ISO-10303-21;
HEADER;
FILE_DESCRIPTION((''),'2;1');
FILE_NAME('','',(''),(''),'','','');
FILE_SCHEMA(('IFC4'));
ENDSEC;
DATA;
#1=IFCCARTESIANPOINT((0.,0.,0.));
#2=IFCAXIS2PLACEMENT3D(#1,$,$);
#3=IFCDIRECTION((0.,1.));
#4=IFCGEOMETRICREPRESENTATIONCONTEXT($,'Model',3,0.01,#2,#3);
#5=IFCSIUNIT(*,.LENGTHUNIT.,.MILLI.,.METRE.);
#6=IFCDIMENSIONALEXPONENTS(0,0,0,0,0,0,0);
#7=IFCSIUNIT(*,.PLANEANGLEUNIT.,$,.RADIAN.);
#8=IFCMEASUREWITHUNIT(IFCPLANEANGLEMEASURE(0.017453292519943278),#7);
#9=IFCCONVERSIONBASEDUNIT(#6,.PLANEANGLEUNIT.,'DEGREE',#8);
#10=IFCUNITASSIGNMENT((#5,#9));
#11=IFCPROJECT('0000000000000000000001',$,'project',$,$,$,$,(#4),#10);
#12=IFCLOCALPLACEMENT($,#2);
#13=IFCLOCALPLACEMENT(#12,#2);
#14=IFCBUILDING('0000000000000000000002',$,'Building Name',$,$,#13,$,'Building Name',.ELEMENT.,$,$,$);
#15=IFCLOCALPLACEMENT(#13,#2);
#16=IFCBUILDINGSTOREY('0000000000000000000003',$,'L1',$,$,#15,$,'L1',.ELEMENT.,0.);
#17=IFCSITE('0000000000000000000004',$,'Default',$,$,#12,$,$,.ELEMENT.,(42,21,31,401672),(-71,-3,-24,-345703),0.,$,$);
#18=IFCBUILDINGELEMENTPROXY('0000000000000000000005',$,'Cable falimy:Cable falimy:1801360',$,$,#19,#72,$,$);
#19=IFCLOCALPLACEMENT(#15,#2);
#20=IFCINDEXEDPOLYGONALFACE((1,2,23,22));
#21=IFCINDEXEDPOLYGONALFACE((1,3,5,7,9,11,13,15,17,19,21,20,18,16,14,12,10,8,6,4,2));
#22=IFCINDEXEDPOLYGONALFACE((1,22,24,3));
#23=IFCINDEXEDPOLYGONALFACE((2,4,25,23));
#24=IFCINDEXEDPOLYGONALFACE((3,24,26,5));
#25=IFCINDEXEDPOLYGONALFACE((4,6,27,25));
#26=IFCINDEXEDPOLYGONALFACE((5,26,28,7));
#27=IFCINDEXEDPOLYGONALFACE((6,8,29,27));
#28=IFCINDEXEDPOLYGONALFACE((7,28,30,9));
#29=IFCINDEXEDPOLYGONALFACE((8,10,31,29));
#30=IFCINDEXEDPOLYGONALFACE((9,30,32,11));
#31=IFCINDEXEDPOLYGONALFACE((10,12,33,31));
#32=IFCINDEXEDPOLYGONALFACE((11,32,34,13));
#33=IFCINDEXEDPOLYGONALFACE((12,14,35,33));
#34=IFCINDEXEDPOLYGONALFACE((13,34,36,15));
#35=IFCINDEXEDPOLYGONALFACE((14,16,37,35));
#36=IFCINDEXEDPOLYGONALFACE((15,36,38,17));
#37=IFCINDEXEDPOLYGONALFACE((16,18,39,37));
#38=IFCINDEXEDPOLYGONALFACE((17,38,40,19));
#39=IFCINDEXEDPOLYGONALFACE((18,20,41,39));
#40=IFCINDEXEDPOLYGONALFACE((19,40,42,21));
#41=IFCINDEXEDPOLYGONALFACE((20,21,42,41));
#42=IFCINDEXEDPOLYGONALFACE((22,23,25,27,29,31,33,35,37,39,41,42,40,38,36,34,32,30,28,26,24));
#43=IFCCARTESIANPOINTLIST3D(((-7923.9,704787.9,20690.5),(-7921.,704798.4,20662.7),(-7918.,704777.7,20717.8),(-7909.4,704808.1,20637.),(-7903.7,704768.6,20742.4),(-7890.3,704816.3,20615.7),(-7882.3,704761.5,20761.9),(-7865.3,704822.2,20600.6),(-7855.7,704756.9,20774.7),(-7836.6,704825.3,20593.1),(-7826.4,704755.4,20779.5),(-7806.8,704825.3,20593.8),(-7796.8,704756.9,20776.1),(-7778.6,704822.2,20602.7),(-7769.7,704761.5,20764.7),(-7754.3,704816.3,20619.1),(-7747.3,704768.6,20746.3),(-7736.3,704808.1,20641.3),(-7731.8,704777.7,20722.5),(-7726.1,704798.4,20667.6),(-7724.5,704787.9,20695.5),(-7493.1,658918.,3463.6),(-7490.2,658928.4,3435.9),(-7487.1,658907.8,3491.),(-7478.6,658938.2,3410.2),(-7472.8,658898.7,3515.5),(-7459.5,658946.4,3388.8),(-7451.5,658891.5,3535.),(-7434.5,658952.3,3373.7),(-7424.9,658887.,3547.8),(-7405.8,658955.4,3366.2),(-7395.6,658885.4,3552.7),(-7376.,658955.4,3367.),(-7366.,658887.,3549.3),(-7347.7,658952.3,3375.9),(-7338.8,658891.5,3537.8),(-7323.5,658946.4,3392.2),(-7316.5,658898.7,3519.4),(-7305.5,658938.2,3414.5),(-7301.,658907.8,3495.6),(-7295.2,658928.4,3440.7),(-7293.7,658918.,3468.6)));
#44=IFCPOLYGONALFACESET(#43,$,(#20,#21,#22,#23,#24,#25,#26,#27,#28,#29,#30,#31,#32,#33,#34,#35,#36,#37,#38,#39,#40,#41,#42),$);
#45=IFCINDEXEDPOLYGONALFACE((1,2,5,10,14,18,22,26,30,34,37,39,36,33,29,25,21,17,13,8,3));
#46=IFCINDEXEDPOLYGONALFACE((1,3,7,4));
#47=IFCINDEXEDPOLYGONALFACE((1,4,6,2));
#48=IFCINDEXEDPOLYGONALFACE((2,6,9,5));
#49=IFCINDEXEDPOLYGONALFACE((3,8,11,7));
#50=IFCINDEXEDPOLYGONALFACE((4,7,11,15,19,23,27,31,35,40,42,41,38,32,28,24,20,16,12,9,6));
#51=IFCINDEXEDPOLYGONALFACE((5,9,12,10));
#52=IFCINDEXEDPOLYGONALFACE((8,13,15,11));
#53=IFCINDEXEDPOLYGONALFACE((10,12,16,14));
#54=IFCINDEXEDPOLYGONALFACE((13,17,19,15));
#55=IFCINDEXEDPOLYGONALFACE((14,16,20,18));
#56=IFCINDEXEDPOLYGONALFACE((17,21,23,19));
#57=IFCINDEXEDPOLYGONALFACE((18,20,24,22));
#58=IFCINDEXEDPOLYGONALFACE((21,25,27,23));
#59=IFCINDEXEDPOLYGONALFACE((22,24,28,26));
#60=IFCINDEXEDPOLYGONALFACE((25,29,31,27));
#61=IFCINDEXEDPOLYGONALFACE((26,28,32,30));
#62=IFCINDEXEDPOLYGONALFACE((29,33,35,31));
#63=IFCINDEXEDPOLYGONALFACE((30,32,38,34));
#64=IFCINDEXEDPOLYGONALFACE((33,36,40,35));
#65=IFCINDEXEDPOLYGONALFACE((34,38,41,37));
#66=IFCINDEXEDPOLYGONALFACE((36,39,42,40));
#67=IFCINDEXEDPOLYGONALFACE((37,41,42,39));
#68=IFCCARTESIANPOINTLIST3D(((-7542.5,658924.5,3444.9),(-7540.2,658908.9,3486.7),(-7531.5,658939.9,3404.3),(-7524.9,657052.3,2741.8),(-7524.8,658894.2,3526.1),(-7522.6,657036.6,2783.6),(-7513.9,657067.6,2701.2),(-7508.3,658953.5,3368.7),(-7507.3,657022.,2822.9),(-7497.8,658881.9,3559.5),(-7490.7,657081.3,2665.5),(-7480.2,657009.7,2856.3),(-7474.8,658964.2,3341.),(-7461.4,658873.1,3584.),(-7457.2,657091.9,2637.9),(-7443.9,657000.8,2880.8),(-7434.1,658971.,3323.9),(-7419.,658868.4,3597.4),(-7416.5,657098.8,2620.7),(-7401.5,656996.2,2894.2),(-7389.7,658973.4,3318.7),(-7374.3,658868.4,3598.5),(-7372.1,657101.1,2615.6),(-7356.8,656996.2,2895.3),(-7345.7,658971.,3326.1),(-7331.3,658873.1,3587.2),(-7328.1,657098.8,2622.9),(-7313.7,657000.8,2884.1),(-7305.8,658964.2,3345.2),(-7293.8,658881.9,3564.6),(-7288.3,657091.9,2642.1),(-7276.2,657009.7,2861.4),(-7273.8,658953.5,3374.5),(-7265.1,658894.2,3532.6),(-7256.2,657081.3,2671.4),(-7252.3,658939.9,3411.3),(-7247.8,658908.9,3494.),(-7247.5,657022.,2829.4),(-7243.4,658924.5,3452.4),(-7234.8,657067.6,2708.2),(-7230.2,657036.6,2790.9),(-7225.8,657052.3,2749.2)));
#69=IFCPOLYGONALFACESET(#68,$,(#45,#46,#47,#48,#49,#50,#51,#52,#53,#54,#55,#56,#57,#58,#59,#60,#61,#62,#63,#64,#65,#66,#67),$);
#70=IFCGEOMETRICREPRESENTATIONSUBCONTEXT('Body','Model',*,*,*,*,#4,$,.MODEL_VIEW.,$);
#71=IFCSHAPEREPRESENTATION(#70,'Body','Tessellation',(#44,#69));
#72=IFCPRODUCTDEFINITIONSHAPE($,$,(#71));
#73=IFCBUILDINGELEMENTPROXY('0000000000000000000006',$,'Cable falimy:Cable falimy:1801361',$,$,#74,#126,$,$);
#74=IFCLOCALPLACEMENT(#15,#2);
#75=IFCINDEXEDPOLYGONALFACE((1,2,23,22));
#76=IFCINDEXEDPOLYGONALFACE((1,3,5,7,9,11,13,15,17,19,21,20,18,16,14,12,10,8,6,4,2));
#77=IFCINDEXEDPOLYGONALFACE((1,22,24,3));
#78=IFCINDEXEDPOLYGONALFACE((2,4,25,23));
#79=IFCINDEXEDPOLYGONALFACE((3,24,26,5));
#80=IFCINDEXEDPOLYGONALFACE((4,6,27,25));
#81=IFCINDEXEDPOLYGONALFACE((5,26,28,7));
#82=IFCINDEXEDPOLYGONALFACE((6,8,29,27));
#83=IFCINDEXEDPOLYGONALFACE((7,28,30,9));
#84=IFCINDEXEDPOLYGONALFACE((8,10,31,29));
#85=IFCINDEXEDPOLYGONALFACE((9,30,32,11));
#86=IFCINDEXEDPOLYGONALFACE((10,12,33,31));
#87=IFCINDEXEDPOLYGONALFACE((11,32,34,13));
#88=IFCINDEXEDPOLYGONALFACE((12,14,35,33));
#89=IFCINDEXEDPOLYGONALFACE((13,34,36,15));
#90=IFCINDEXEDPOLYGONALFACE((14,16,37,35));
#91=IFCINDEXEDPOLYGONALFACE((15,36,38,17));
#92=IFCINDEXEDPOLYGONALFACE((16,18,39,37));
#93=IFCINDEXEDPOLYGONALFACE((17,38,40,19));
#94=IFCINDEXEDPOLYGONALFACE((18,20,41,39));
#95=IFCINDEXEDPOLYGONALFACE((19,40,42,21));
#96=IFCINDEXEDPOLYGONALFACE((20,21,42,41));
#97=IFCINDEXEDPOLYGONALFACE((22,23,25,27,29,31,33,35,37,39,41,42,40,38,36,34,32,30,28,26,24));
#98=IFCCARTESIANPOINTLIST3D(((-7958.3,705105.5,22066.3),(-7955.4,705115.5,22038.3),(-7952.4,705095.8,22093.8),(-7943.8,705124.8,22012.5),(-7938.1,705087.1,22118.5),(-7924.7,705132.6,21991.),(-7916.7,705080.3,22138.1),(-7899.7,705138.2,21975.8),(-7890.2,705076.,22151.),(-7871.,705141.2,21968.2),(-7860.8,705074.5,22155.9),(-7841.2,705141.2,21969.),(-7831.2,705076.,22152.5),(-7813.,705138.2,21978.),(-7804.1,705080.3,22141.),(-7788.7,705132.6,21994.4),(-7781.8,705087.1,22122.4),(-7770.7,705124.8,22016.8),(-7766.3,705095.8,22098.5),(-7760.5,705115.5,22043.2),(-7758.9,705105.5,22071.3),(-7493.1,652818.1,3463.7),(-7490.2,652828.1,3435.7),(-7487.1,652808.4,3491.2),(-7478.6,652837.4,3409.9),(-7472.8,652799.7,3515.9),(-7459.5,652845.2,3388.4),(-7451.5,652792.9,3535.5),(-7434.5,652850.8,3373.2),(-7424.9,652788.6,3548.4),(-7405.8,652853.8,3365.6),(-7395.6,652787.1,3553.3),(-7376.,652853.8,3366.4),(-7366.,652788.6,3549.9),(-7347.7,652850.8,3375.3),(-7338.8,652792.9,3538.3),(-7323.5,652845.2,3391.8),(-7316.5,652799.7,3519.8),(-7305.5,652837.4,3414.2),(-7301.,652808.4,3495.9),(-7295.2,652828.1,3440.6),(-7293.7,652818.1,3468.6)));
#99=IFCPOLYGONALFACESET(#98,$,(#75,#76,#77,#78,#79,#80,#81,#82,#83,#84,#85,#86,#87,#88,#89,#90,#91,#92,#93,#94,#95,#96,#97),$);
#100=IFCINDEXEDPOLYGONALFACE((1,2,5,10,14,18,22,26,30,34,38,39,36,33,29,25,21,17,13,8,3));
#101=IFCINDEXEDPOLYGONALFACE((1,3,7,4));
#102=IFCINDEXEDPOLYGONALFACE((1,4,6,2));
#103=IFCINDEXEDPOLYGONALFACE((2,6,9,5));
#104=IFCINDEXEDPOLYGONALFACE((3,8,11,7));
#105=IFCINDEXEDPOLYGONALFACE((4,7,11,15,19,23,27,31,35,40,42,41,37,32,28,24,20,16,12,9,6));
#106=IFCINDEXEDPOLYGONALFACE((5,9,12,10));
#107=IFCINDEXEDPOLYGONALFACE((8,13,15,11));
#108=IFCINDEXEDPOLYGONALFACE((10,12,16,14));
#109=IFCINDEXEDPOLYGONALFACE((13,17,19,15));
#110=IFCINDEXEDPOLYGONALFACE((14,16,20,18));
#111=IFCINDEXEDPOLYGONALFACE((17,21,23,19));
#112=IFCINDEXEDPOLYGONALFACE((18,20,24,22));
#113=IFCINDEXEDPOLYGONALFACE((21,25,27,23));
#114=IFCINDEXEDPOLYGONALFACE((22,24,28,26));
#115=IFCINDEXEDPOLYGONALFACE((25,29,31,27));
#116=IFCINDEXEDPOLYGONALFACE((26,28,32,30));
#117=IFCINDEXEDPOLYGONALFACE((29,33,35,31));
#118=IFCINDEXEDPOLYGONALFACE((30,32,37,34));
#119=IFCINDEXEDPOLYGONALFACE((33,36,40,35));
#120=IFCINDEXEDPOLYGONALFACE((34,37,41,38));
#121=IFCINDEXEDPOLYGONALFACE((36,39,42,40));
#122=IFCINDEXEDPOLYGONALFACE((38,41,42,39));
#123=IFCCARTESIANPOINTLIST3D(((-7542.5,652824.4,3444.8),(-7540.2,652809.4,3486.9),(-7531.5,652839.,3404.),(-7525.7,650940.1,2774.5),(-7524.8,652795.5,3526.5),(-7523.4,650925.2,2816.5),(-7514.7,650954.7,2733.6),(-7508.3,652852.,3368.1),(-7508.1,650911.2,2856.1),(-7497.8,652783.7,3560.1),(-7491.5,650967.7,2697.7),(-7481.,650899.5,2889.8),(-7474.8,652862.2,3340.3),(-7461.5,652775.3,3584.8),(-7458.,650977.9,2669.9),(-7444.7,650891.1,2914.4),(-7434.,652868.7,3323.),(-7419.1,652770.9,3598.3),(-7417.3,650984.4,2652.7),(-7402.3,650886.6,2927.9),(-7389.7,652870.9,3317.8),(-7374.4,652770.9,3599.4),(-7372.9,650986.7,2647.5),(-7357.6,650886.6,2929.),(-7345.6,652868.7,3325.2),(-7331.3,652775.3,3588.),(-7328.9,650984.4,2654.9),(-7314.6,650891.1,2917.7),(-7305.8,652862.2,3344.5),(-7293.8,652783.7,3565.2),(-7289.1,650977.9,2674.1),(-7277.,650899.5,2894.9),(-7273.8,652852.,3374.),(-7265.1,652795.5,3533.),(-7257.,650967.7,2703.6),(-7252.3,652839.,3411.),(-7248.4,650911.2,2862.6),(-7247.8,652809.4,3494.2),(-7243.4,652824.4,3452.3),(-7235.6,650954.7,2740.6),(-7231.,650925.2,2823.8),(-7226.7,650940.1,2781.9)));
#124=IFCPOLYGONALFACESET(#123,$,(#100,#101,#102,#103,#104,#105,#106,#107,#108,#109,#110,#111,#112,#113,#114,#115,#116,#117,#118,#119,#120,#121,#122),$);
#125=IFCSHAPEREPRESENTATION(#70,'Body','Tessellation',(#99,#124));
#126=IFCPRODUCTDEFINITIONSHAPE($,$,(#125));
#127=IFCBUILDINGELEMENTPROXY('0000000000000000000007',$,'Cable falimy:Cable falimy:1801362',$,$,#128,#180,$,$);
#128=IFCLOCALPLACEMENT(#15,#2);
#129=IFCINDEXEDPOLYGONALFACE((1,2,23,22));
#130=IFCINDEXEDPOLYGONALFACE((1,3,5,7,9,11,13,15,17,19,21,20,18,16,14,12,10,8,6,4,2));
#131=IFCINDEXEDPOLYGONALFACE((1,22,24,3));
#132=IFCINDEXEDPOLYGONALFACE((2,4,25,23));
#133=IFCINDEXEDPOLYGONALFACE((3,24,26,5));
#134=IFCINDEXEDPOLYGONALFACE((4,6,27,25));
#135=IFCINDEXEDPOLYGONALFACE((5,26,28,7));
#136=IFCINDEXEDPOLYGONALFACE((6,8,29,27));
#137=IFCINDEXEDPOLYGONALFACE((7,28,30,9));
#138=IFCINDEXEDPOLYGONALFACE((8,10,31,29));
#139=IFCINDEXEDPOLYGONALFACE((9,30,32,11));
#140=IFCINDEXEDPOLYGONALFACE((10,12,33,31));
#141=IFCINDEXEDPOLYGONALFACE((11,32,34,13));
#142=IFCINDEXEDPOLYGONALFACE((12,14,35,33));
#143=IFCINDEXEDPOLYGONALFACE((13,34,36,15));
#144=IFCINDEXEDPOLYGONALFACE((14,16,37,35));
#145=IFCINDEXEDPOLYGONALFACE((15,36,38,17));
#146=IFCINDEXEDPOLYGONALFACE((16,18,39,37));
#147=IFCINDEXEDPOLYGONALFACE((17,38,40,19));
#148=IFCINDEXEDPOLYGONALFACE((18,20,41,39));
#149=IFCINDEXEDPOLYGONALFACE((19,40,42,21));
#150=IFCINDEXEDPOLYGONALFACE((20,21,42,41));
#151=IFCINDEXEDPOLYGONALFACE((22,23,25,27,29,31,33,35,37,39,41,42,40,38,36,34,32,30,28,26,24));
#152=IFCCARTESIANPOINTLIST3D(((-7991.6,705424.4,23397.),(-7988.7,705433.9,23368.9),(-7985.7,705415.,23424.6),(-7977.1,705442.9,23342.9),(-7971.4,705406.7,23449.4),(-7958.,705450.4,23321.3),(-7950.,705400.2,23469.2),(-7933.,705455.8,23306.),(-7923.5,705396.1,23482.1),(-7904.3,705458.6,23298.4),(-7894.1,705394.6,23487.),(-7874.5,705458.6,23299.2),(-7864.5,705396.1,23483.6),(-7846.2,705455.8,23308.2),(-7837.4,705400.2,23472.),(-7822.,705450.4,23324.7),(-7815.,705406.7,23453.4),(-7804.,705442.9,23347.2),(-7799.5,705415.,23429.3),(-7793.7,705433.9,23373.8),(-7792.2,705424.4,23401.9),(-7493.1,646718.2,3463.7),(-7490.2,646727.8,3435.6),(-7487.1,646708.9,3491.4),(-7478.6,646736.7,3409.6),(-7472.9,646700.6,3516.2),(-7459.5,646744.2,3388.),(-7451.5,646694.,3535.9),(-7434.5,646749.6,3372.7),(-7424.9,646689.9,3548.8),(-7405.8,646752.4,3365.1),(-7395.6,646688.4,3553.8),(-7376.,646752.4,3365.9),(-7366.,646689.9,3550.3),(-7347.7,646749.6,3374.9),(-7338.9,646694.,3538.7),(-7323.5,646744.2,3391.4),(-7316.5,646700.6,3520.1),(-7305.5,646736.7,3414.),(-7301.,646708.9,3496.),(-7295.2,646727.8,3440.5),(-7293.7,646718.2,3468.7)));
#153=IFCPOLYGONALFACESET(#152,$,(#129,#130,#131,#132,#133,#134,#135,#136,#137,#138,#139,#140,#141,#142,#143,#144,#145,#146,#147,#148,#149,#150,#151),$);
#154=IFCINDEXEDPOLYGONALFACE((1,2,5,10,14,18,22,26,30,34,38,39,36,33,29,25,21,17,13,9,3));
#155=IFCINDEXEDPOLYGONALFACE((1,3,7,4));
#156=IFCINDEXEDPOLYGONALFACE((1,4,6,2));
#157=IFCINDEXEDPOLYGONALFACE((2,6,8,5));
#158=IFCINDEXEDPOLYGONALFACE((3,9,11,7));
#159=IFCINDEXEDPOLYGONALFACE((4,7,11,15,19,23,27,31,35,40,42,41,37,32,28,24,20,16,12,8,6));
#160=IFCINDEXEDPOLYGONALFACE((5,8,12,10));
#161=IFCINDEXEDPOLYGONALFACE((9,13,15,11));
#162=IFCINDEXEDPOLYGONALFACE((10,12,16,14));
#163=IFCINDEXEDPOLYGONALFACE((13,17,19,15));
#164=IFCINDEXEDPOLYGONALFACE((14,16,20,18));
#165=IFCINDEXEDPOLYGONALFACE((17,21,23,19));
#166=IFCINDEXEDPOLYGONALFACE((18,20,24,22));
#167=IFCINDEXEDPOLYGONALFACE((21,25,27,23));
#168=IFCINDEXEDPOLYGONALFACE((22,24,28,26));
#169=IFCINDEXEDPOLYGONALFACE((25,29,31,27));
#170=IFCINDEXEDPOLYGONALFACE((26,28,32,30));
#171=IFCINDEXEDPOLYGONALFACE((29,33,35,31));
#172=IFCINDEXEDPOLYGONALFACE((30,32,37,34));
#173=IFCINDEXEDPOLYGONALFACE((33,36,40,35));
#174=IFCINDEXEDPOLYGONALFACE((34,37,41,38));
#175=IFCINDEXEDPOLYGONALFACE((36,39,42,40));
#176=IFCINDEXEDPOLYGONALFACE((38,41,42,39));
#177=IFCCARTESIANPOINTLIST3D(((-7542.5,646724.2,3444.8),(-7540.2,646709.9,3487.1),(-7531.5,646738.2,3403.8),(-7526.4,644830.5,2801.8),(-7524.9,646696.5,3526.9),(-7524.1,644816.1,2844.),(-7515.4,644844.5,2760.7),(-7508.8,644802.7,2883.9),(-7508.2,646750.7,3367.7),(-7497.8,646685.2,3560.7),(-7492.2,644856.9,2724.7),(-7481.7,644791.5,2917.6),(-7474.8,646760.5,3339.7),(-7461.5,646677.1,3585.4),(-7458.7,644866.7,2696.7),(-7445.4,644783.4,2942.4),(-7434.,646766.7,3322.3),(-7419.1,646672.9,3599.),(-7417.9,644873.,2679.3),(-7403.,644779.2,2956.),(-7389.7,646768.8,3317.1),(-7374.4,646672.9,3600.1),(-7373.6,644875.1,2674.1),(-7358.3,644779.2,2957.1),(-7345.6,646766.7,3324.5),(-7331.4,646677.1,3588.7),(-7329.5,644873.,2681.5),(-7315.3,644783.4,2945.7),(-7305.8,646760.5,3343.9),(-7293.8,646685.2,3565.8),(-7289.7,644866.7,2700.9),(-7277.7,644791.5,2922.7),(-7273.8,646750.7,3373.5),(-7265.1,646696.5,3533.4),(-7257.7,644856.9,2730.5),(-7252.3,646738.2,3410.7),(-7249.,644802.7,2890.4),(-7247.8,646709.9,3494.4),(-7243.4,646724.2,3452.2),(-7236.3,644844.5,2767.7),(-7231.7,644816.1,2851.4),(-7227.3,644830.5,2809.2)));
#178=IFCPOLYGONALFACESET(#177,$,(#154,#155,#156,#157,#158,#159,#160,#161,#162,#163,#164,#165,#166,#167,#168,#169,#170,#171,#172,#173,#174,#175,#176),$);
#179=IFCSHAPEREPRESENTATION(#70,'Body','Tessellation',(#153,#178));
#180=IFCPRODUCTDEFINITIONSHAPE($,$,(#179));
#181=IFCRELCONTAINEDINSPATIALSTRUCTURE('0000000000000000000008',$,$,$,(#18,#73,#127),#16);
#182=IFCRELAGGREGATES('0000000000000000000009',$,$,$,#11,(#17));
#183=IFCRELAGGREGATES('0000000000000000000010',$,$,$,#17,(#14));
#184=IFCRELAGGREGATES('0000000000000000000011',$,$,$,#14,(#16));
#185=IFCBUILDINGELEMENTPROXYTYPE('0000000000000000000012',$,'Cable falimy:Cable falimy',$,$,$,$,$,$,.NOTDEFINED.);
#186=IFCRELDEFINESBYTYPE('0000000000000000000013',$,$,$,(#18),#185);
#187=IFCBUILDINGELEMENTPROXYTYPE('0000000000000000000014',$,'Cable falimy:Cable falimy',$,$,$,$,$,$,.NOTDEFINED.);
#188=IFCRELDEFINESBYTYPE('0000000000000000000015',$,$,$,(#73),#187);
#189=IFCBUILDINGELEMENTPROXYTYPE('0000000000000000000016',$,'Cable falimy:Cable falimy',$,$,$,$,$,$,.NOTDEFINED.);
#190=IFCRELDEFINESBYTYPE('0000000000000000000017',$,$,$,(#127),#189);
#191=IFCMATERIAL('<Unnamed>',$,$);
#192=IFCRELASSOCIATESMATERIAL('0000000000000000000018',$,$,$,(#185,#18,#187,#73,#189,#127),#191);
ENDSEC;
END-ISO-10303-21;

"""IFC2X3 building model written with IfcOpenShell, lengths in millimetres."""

from ifc_helpers import new_model, entity, si_unit, converted_unit, direction, frame, frame_2d, origin, place, context, subcontext, project, spatial, circle, extrude, source, transform, mapped, material, type_object, type_shapes, element, save


model = new_model("IFC2X3")

# Units and contexts
model_context = context("Model", 3, precision=0.01, world=origin(), true_north=direction((0.0, 1.0)))
body_context = subcontext(model_context, "Body", "Model", "MODEL_VIEW")
ifc_project = project(units=[si_unit("LENGTHUNIT", "METRE", prefix="MILLI"), converted_unit("PLANEANGLEUNIT", "DEGREE", entity("IfcPlaneAngleMeasure", 0.017453292519943278), si_unit("PLANEANGLEUNIT", "RADIAN"), dimensions=[0, 0, 0, 0, 0, 0, 0])], contexts=[model_context])

# Site, building, storey
site_placement = place(None, origin())
site = spatial("IfcSite", under=ifc_project, at=site_placement, Name="Default", CompositionType="ELEMENT", RefLatitude=(42, 21, 31, 401672), RefLongitude=(-71, -3, -24, -345703), RefElevation=0.0)
building_placement = place(site_placement, origin())
building = spatial("IfcBuilding", under=site, at=building_placement, Name="Building Name", LongName="Building Name", CompositionType="ELEMENT")
storey_placement = place(building_placement, origin())
storey = spatial("IfcBuildingStorey", under=building, at=storey_placement, Name="L1", LongName="L1", CompositionType="ELEMENT", Elevation=0.0)

# Shared definitions
ifc_material = material(Name="<Unnamed>")

# Building element proxies
building_element_proxy_type_1 = type_object("IfcBuildingElementProxyType", Name="Cable falimy:Cable falimy", PredefinedType="NOTDEFINED", material=ifc_material)
shared_shape_1 = source(origin(), body_context, "Body", "SweptSolid", [
    extrude(circle(Radius=100.0, at=frame_2d((0.0, 0.0), x_axis=(1.0, 0.0))), frame((0.0, 0.0, 0.0), z_axis=(0.936121, 0.0, 0.351678), x_axis=(-0.351678, 0.0, 0.936121)), (0.0, 0.0, 1.0), 49000.0),
    extrude(circle(Radius=150.0, at=frame_2d((0.0, 0.0), x_axis=(1.0, 0.0))), frame((-1872.2, 0.0, -703.4), z_axis=(0.936121, 0.0, 0.351678), x_axis=(0.351678, 0.0, -0.936121)), (0.0, 0.0, 1.0), 2000.0),
])
type_shapes(building_element_proxy_type_1, [shared_shape_1])
proxy_1_placement = place(storey_placement, frame((-7393.2, 658920.6, 3459.1), z_axis=(-0.025001, 0.0, 0.999687), x_axis=(0.0, 1.0, 0.0)))
element("IfcBuildingElementProxy", 1, at=proxy_1_placement, inside=storey, type_object=building_element_proxy_type_1, material=ifc_material, Name="Cable falimy:Cable falimy:1801360", context=body_context, shape_type="MappedRepresentation", body=[
    mapped(shared_shape_1, transform((0.0, 0.0, 0.0), scale=1.0)),
])
building_element_proxy_type_2 = type_object("IfcBuildingElementProxyType", Name="Cable falimy:Cable falimy", PredefinedType="NOTDEFINED", material=ifc_material)
shared_shape_2 = source(origin(), body_context, "Body", "SweptSolid", [
    extrude(circle(Radius=100.0, at=frame_2d((0.0, 0.0), x_axis=(1.0, 0.0))), frame((0.0, 0.0, 0.0), z_axis=(0.942116, 0.0, 0.335287), x_axis=(-0.335287, 0.0, 0.942116)), (0.0, 0.0, 1.0), 55500.0),
    extrude(circle(Radius=150.0, at=frame_2d((0.0, 0.0), x_axis=(1.0, 0.0))), frame((-1884.2, 0.0, -670.6), z_axis=(0.942116, 0.0, 0.335287), x_axis=(0.335287, 0.0, -0.942116)), (0.0, 0.0, 1.0), 2000.0),
])
type_shapes(building_element_proxy_type_2, [shared_shape_2])
proxy_2_placement = place(storey_placement, frame((-7393.2, 652820.6, 3459.1), z_axis=(-0.025001, 0.0, 0.999687), x_axis=(0.0, 1.0, 0.0)))
element("IfcBuildingElementProxy", 2, at=proxy_2_placement, inside=storey, type_object=building_element_proxy_type_2, material=ifc_material, Name="Cable falimy:Cable falimy:1801361", context=body_context, shape_type="MappedRepresentation", body=[
    mapped(shared_shape_2, transform((0.0, 0.0, 0.0), scale=1.0)),
])
building_element_proxy_type_3 = type_object("IfcBuildingElementProxyType", Name="Cable falimy:Cable falimy", PredefinedType="NOTDEFINED", material=ifc_material)
shared_shape_3 = source(origin(), body_context, "Body", "SweptSolid", [
    extrude(circle(Radius=100.0, at=frame_2d((0.0, 0.0), x_axis=(1.0, 0.0))), frame((0.0, 0.0, 0.0), z_axis=(0.946874, 0.0, 0.321605), x_axis=(-0.321605, 0.0, 0.946874)), (0.0, 0.0, 1.0), 62000.0),
    extrude(circle(Radius=150.0, at=frame_2d((0.0, 0.0), x_axis=(1.0, 0.0))), frame((-1893.7, 0.0, -643.2), z_axis=(0.946874, 0.0, 0.321605), x_axis=(0.321605, 0.0, -0.946874)), (0.0, 0.0, 1.0), 2000.0),
])
type_shapes(building_element_proxy_type_3, [shared_shape_3])
proxy_3_placement = place(storey_placement, frame((-7393.2, 646720.6, 3459.1), z_axis=(-0.025001, 0.0, 0.999687), x_axis=(0.0, 1.0, 0.0)))
element("IfcBuildingElementProxy", 3, at=proxy_3_placement, inside=storey, type_object=building_element_proxy_type_3, material=ifc_material, Name="Cable falimy:Cable falimy:1801362", context=body_context, shape_type="MappedRepresentation", body=[
    mapped(shared_shape_3, transform((0.0, 0.0, 0.0), scale=1.0)),
])

save(model, "model.ifc")
